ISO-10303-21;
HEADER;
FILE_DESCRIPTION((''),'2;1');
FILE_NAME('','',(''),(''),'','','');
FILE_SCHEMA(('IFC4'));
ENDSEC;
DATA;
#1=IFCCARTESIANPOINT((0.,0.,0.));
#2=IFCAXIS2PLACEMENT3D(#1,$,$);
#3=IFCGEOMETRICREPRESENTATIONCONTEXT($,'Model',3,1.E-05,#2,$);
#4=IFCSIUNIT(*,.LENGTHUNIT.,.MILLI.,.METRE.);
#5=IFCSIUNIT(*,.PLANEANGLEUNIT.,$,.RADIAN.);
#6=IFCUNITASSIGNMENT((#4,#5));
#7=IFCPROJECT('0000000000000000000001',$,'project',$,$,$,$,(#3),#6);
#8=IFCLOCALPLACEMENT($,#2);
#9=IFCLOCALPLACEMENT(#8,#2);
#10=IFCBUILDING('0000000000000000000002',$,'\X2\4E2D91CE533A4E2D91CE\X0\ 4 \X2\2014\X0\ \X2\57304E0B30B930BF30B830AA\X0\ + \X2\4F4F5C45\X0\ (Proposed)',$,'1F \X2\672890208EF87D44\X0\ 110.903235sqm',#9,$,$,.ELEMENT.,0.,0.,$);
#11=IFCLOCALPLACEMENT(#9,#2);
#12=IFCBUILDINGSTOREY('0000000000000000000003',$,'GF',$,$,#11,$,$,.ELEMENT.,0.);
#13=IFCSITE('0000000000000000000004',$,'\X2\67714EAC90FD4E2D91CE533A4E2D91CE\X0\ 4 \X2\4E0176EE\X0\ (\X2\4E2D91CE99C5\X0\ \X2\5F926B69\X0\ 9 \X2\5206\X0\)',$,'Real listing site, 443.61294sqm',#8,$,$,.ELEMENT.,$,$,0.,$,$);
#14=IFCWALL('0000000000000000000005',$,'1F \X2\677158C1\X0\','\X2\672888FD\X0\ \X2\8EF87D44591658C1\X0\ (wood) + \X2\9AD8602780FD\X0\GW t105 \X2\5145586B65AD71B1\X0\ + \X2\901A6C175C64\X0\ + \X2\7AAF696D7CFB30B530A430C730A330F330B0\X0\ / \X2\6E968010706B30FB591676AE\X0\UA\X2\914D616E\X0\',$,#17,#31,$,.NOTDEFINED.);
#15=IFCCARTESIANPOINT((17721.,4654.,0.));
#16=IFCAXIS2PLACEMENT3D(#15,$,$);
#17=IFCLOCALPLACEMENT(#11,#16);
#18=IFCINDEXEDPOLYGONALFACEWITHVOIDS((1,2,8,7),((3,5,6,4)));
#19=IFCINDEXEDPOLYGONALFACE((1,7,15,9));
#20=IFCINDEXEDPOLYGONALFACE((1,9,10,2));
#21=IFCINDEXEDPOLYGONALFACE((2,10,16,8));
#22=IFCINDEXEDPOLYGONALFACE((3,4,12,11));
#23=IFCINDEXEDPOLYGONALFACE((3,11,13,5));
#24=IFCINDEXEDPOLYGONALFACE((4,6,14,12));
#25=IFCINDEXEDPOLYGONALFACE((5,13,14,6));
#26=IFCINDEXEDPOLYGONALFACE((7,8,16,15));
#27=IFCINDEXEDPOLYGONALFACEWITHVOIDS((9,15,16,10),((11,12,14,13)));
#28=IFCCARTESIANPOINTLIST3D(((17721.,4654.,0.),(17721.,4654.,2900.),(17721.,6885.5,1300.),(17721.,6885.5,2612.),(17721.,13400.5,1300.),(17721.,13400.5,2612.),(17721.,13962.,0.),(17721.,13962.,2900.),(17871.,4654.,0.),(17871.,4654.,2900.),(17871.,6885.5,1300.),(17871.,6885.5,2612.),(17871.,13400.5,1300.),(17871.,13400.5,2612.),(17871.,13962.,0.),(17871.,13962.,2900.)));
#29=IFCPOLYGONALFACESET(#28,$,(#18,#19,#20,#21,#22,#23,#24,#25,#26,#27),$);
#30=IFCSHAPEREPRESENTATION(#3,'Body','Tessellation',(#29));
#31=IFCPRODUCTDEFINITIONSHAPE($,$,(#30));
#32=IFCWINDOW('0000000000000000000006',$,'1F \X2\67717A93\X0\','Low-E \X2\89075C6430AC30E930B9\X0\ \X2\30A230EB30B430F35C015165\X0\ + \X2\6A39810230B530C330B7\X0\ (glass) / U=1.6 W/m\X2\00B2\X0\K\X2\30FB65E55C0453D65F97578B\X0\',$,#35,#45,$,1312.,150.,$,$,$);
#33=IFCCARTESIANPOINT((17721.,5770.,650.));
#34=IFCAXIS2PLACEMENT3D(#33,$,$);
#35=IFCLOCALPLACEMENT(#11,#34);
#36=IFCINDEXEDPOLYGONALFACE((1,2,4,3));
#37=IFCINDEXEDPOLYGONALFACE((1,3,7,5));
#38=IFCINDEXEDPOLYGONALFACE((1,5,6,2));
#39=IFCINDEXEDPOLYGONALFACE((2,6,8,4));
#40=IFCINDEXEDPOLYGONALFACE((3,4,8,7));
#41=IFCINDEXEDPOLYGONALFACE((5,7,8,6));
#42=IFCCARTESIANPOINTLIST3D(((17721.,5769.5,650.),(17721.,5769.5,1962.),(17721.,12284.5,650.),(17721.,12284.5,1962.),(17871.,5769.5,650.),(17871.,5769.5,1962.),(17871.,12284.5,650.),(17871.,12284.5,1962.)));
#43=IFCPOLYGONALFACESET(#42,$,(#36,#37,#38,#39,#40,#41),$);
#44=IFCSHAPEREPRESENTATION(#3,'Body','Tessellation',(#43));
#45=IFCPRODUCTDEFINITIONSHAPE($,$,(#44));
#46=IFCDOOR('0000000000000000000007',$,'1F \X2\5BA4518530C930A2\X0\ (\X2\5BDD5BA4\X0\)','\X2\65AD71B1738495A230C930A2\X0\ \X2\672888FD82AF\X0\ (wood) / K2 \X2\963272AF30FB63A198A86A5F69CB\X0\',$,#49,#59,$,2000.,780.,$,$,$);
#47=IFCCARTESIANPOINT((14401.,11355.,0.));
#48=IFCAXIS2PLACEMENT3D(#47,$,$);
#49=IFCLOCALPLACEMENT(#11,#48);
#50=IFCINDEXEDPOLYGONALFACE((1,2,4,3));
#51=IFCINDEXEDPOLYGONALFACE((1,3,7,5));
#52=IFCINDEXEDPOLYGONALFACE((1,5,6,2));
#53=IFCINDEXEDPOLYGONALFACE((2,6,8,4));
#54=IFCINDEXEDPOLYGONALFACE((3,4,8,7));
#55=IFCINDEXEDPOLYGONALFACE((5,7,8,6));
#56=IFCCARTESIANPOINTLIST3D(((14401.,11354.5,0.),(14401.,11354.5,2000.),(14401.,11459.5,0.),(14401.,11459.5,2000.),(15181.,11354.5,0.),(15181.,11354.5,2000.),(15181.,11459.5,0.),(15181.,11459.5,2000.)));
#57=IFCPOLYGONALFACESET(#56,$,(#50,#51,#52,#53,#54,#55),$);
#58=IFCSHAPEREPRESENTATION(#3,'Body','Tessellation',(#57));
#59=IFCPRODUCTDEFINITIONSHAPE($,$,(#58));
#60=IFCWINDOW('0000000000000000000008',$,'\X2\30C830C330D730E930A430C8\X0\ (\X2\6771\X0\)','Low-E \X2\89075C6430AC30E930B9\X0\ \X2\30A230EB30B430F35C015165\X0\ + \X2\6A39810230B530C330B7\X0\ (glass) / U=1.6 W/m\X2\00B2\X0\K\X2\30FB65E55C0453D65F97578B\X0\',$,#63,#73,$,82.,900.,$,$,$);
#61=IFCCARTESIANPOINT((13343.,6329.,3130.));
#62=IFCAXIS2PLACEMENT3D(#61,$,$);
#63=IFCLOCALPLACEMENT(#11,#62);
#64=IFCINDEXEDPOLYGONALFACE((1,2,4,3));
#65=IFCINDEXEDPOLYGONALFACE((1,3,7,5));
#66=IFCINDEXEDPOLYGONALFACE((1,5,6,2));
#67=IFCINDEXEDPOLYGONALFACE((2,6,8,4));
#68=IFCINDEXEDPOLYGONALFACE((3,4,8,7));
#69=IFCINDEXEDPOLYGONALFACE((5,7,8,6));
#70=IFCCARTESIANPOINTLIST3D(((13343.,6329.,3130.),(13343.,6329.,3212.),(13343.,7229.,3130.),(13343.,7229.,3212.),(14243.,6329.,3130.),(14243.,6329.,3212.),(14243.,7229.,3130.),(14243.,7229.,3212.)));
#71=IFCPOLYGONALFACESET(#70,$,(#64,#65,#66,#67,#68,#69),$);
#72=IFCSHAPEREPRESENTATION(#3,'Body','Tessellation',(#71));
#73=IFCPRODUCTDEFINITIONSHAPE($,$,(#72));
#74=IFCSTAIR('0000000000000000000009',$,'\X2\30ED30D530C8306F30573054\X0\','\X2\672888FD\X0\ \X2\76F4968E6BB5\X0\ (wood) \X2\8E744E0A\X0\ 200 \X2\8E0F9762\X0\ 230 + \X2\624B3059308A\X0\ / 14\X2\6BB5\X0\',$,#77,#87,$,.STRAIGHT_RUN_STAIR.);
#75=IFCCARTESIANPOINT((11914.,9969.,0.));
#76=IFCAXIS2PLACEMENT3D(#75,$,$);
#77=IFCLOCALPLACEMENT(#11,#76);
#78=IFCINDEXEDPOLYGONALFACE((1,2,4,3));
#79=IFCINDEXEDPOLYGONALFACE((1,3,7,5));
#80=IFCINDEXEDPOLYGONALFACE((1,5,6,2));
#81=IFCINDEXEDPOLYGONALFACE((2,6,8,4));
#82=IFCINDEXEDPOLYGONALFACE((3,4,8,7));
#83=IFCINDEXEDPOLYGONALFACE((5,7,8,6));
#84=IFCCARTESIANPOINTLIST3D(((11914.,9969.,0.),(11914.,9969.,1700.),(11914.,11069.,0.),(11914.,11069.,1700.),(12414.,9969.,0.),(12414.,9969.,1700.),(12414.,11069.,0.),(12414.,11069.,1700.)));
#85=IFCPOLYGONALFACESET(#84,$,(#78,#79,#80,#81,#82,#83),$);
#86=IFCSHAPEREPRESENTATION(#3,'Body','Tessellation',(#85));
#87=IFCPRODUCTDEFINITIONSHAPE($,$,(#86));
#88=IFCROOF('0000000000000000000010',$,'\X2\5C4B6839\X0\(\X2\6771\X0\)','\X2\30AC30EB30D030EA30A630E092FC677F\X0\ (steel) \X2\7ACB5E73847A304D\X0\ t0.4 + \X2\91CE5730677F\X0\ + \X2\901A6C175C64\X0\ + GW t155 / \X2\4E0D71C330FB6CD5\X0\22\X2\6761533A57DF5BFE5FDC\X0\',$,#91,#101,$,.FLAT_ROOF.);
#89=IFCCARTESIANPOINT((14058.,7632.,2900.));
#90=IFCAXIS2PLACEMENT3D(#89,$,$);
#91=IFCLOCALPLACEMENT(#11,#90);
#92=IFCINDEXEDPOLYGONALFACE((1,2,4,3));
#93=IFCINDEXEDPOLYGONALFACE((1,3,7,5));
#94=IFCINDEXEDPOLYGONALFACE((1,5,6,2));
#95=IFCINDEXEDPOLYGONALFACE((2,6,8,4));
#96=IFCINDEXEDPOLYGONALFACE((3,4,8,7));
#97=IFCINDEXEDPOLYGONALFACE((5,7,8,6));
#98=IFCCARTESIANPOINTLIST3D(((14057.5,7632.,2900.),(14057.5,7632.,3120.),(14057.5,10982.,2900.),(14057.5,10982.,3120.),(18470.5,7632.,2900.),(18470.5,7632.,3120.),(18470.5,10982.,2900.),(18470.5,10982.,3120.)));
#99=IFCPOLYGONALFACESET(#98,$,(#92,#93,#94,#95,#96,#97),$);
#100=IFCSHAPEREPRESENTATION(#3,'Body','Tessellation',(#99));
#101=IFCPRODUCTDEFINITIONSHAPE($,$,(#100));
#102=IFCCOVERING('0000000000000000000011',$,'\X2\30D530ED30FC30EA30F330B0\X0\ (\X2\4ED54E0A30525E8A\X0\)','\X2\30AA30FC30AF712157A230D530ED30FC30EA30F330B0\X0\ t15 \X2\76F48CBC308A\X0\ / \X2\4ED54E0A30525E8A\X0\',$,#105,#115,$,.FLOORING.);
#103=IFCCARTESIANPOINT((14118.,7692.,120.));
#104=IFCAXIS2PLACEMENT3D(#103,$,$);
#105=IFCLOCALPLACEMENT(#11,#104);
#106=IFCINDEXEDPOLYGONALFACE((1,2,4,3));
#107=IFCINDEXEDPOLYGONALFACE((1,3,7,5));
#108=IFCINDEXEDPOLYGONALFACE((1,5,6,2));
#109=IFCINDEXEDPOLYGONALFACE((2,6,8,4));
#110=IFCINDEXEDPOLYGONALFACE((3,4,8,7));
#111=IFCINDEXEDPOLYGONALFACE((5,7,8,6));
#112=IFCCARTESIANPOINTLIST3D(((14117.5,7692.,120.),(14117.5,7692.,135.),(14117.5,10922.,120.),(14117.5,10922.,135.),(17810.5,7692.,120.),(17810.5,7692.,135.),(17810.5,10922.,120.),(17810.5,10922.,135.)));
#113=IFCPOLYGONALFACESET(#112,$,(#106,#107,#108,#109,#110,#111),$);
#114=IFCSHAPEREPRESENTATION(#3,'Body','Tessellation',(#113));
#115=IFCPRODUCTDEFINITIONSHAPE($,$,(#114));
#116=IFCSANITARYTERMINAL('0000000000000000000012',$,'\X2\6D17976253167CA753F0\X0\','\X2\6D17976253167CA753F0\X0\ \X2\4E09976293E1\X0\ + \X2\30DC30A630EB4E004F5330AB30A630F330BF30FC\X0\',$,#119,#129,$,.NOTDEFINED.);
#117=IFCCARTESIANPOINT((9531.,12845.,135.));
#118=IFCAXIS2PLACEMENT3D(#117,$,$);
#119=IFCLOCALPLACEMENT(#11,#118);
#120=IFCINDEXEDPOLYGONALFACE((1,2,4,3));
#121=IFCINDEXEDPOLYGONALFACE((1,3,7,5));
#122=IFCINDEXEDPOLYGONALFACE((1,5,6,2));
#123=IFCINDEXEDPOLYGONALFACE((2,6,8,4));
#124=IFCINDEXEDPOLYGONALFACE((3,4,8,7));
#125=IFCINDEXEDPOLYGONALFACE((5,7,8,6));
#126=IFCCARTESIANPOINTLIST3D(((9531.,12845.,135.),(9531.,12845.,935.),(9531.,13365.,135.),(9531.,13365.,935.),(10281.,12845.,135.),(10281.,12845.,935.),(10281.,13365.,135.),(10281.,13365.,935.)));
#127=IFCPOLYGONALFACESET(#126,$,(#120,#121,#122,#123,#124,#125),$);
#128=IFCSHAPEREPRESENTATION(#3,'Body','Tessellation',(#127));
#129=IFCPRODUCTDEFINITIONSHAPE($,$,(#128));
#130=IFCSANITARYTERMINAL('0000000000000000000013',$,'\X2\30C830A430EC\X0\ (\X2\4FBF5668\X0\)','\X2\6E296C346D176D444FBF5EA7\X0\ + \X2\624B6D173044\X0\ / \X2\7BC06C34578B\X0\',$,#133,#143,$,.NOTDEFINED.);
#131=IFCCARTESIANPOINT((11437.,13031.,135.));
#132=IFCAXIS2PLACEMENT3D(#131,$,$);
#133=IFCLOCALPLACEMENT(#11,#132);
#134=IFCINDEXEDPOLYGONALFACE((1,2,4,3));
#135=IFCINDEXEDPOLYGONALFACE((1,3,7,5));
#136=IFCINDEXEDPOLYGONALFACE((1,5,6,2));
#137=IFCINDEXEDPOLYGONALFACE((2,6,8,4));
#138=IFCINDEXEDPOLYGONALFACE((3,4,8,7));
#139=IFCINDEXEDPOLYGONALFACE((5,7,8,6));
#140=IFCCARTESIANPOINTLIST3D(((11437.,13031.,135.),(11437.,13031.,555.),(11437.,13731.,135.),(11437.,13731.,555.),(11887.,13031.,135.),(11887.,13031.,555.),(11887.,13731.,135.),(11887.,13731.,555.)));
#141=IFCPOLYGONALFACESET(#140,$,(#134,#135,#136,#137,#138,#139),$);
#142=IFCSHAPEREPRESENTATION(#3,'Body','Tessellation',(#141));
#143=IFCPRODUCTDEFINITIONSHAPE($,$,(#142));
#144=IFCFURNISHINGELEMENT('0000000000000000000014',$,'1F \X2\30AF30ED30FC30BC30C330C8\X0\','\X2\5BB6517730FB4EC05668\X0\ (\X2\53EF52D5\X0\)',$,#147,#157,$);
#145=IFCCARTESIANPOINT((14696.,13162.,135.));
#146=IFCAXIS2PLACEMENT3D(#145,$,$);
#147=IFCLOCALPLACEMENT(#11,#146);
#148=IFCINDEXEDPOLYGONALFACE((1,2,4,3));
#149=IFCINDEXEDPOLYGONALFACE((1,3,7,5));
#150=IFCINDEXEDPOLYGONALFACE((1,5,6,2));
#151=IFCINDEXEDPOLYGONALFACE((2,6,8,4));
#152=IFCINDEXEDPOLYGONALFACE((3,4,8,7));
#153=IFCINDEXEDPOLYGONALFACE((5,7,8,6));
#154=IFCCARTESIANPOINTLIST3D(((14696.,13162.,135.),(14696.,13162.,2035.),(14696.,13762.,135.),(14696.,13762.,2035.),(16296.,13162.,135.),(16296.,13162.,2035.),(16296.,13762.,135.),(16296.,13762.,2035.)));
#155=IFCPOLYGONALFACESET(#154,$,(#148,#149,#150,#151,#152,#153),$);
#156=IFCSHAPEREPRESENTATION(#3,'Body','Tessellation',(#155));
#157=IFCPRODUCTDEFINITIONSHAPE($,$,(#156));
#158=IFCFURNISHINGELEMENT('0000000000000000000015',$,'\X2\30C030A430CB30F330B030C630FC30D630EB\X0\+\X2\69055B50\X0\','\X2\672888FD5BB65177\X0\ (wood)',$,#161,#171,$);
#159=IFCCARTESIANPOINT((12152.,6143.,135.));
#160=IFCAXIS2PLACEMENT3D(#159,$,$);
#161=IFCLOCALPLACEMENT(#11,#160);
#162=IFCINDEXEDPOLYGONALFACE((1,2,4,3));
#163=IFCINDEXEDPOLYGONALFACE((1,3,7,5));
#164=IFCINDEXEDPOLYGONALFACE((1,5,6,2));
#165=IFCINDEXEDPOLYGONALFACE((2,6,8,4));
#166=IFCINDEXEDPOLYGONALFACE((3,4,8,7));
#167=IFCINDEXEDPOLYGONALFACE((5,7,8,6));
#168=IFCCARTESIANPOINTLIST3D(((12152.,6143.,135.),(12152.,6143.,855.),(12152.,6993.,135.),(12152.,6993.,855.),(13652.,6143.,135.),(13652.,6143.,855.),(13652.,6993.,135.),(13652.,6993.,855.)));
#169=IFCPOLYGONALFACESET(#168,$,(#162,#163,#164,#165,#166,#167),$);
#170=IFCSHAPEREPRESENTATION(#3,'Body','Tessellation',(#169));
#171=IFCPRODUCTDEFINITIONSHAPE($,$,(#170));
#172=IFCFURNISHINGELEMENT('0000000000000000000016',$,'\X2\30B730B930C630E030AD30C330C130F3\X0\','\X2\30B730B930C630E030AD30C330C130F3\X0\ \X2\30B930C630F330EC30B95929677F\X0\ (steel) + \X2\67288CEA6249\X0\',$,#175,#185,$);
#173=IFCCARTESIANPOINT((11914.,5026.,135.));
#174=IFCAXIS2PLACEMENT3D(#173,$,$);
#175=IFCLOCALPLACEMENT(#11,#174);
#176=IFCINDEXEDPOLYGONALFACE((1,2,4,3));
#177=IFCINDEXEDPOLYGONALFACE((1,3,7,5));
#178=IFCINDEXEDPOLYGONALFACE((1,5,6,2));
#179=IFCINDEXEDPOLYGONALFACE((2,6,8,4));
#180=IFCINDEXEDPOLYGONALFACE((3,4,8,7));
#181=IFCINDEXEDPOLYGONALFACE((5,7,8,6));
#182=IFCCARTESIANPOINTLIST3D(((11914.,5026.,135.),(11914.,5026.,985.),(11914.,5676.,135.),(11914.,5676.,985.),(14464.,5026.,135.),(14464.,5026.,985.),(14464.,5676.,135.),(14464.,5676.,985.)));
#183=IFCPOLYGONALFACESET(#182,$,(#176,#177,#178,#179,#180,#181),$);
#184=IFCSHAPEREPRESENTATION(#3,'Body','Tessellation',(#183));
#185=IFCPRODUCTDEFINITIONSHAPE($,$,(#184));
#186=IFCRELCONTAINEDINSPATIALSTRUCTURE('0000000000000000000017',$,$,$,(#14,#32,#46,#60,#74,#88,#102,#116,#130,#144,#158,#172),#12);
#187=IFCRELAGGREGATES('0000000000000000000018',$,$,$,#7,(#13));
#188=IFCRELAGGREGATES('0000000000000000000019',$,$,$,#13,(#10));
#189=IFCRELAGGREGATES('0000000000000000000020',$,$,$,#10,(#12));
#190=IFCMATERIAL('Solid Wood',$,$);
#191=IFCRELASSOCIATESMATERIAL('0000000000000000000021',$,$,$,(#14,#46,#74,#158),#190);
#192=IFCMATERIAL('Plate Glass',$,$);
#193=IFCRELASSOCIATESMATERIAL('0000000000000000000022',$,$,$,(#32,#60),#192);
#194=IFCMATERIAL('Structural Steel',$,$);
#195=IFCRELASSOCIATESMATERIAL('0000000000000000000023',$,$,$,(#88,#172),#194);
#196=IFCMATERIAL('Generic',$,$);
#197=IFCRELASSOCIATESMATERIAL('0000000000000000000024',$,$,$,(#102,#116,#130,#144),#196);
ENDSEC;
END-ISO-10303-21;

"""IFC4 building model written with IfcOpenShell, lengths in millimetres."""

from ifc_helpers import new_model, si_unit, frame, frame_2d, origin, place, context, project, spatial, rectangle, extrude, material, element, fill, save


model = new_model("IFC4")

# Units and contexts
model_context = context("Model", 3, precision=1e-05, world=origin())
ifc_project = project(units=[si_unit("LENGTHUNIT", "METRE", prefix="MILLI"), si_unit("PLANEANGLEUNIT", "RADIAN")], contexts=[model_context])

# Site, building, storey
site_placement = place(None, origin())
site = spatial("IfcSite", under=ifc_project, at=site_placement, Name="東京都中野区中野 4 丁目 (中野駅 徒歩 9 分)", ObjectType="Real listing site, 443.61294sqm", CompositionType="ELEMENT", RefElevation=0.0)
building_placement = place(site_placement, origin())
building = spatial("IfcBuilding", under=site, at=building_placement, Name="中野区中野 4 — 地下スタジオ + 住居 (Proposed)", ObjectType="1F 木造軸組 110.903235sqm", CompositionType="ELEMENT", ElevationOfRefHeight=0.0, ElevationOfTerrain=0.0)
storey_placement = place(building_placement, origin())
storey = spatial("IfcBuildingStorey", under=building, at=storey_placement, Name="GF", CompositionType="ELEMENT", Elevation=0.0)

# Shared definitions
ifc_material_1 = material(Name="Solid Wood")

# Wall, opening, window
wall_1_placement = place(storey_placement, frame((17721.0, 4654.0, 0.0)))
wall_1 = element("IfcWall", 1, at=wall_1_placement, inside=storey, material=ifc_material_1, Name="1F 東壁", Description="木製 軸組外壁 (wood) + 高性能GW t105 充填断熱 + 通気層 + 窯業系サイディング / 準耐火・外皮UA配慮", PredefinedType="NOTDEFINED", context=model_context, shape_type="SweptSolid", body=[
    extrude(rectangle(XDim=150.0, YDim=9308.0, at=frame_2d((75.0, 4654.0))), frame((17721.0, 4654.0, 0.0)), (0.0, 0.0, 1.0), 2900.0),
])
opening_1_placement = place(storey_placement, frame((17721.0, 5770.0, 650.0)))
opening_1 = element("IfcOpeningElement", 2, at=opening_1_placement, cuts=wall_1, PredefinedType="NOTDEFINED", context=model_context, shape_type="SweptSolid", body=[
    extrude(rectangle(XDim=150.0, YDim=6515.0, at=frame_2d((75.0, 3257.0))), frame((17721.0, 5770.0, 650.0)), (0.0, 0.0, 1.0), 1312.0),
])
ifc_material_2 = material(Name="Plate Glass")
window_1_placement = place(storey_placement, frame((17721.0, 5770.0, 650.0)))
window_1 = element("IfcWindow", 3, at=window_1_placement, inside=storey, material=ifc_material_2, Name="1F 東窓", Description="Low-E 複層ガラス アルゴン封入 + 樹脂サッシ (glass) / U=1.6 W/m²K・日射取得型", OverallHeight=1312.0, OverallWidth=150.0, context=model_context, shape_type="SweptSolid", body=[
    extrude(rectangle(XDim=150.0, YDim=6515.0, at=frame_2d((75.0, 3257.0))), frame((17721.0, 5770.0, 650.0)), (0.0, 0.0, 1.0), 1312.0),
])
fill(opening_1, window_1)

# Door
door_placement = place(storey_placement, frame((14401.0, 11355.0, 0.0)))
element("IfcDoor", 4, at=door_placement, inside=storey, material=ifc_material_1, Name="1F 室内ドア (寝室)", Description="断熱玄関ドア 木製芯 (wood) / K2 防犯・採風機構", OverallHeight=2000.0, OverallWidth=780.0, context=model_context, shape_type="SweptSolid", body=[
    extrude(rectangle(XDim=780.0, YDim=105.0, at=frame_2d((390.0, 52.0))), frame((14401.0, 11355.0, 0.0)), (0.0, 0.0, 1.0), 2000.0),
])

# Window
window_2_placement = place(storey_placement, frame((13343.0, 6329.0, 3130.0)))
element("IfcWindow", 5, at=window_2_placement, inside=storey, material=ifc_material_2, Name="トップライト (東)", Description="Low-E 複層ガラス アルゴン封入 + 樹脂サッシ (glass) / U=1.6 W/m²K・日射取得型", OverallHeight=82.0, OverallWidth=900.0, context=model_context, shape_type="SweptSolid", body=[
    extrude(rectangle(XDim=900.0, YDim=900.0, at=frame_2d((450.0, 450.0))), frame((13343.0, 6329.0, 3130.0)), (0.0, 0.0, 1.0), 82.0),
])

# Stair
stair_placement = place(storey_placement, frame((11914.0, 9969.0, 0.0)))
element("IfcStair", 6, at=stair_placement, inside=storey, material=ifc_material_1, Name="ロフトはしご", Description="木製 直階段 (wood) 蹴上 200 踏面 230 + 手すり / 14段", PredefinedType="STRAIGHT_RUN_STAIR", context=model_context, shape_type="SweptSolid", body=[
    extrude(rectangle(XDim=500.0, YDim=1100.0, at=frame_2d((250.0, 550.0))), frame((11914.0, 9969.0, 0.0)), (0.0, 0.0, 1.0), 1700.0),
])

# Roof
ifc_material_3 = material(Name="Structural Steel")
roof_placement = place(storey_placement, frame((14058.0, 7632.0, 2900.0)))
element("IfcRoof", 7, at=roof_placement, inside=storey, material=ifc_material_3, Name="屋根(東)", Description="ガルバリウム鋼板 (steel) 立平葺き t0.4 + 野地板 + 通気層 + GW t155 / 不燃・法22条区域対応", PredefinedType="FLAT_ROOF", context=model_context, shape_type="SweptSolid", body=[
    extrude(rectangle(XDim=4413.0, YDim=3350.0, at=frame_2d((2206.0, 1675.0))), frame((14058.0, 7632.0, 2900.0)), (0.0, 0.0, 1.0), 220.0),
])

# Covering
ifc_material_4 = material(Name="Generic")
covering_placement = place(storey_placement, frame((14118.0, 7692.0, 120.0)))
element("IfcCovering", 8, at=covering_placement, inside=storey, material=ifc_material_4, Name="フローリング (仕上げ床)", Description="オーク無垢フローリング t15 直貼り / 仕上げ床", PredefinedType="FLOORING", context=model_context, shape_type="SweptSolid", body=[
    extrude(rectangle(XDim=3693.0, YDim=3230.0, at=frame_2d((1846.0, 1615.0))), frame((14118.0, 7692.0, 120.0)), (0.0, 0.0, 1.0), 15.0),
])

# Sanitary terminals
sanitary_terminal_1_placement = place(storey_placement, frame((9531.0, 12845.0, 135.0)))
element("IfcSanitaryTerminal", 9, at=sanitary_terminal_1_placement, inside=storey, material=ifc_material_4, Name="洗面化粧台", Description="洗面化粧台 三面鏡 + ボウル一体カウンター", PredefinedType="NOTDEFINED", context=model_context, shape_type="SweptSolid", body=[
    extrude(rectangle(XDim=750.0, YDim=520.0, at=frame_2d((375.0, 260.0))), frame((9531.0, 12845.0, 135.0)), (0.0, 0.0, 1.0), 800.0),
])
sanitary_terminal_2_placement = place(storey_placement, frame((11437.0, 13031.0, 135.0)))
element("IfcSanitaryTerminal", 10, at=sanitary_terminal_2_placement, inside=storey, material=ifc_material_4, Name="トイレ (便器)", Description="温水洗浄便座 + 手洗い / 節水型", PredefinedType="NOTDEFINED", context=model_context, shape_type="SweptSolid", body=[
    extrude(rectangle(XDim=450.0, YDim=700.0, at=frame_2d((225.0, 350.0))), frame((11437.0, 13031.0, 135.0)), (0.0, 0.0, 1.0), 420.0),
])

# Furnishing elements
furnishing_1_placement = place(storey_placement, frame((14696.0, 13162.0, 135.0)))
element("IfcFurnishingElement", 11, at=furnishing_1_placement, inside=storey, material=ifc_material_4, Name="1F クローゼット", Description="家具・什器 (可動)", context=model_context, shape_type="SweptSolid", body=[
    extrude(rectangle(XDim=1600.0, YDim=600.0, at=frame_2d((800.0, 300.0))), frame((14696.0, 13162.0, 135.0)), (0.0, 0.0, 1.0), 1900.0),
])
furnishing_2_placement = place(storey_placement, frame((12152.0, 6143.0, 135.0)))
element("IfcFurnishingElement", 12, at=furnishing_2_placement, inside=storey, material=ifc_material_1, Name="ダイニングテーブル+椅子", Description="木製家具 (wood)", context=model_context, shape_type="SweptSolid", body=[
    extrude(rectangle(XDim=1500.0, YDim=850.0, at=frame_2d((750.0, 425.0))), frame((12152.0, 6143.0, 135.0)), (0.0, 0.0, 1.0), 720.0),
])
furnishing_3_placement = place(storey_placement, frame((11914.0, 5026.0, 135.0)))
element("IfcFurnishingElement", 13, at=furnishing_3_placement, inside=storey, material=ifc_material_3, Name="システムキッチン", Description="システムキッチン ステンレス天板 (steel) + 木質扉", context=model_context, shape_type="SweptSolid", body=[
    extrude(rectangle(XDim=2550.0, YDim=650.0, at=frame_2d((1275.0, 325.0))), frame((11914.0, 5026.0, 135.0)), (0.0, 0.0, 1.0), 850.0),
])

save(model, "model.ifc")
